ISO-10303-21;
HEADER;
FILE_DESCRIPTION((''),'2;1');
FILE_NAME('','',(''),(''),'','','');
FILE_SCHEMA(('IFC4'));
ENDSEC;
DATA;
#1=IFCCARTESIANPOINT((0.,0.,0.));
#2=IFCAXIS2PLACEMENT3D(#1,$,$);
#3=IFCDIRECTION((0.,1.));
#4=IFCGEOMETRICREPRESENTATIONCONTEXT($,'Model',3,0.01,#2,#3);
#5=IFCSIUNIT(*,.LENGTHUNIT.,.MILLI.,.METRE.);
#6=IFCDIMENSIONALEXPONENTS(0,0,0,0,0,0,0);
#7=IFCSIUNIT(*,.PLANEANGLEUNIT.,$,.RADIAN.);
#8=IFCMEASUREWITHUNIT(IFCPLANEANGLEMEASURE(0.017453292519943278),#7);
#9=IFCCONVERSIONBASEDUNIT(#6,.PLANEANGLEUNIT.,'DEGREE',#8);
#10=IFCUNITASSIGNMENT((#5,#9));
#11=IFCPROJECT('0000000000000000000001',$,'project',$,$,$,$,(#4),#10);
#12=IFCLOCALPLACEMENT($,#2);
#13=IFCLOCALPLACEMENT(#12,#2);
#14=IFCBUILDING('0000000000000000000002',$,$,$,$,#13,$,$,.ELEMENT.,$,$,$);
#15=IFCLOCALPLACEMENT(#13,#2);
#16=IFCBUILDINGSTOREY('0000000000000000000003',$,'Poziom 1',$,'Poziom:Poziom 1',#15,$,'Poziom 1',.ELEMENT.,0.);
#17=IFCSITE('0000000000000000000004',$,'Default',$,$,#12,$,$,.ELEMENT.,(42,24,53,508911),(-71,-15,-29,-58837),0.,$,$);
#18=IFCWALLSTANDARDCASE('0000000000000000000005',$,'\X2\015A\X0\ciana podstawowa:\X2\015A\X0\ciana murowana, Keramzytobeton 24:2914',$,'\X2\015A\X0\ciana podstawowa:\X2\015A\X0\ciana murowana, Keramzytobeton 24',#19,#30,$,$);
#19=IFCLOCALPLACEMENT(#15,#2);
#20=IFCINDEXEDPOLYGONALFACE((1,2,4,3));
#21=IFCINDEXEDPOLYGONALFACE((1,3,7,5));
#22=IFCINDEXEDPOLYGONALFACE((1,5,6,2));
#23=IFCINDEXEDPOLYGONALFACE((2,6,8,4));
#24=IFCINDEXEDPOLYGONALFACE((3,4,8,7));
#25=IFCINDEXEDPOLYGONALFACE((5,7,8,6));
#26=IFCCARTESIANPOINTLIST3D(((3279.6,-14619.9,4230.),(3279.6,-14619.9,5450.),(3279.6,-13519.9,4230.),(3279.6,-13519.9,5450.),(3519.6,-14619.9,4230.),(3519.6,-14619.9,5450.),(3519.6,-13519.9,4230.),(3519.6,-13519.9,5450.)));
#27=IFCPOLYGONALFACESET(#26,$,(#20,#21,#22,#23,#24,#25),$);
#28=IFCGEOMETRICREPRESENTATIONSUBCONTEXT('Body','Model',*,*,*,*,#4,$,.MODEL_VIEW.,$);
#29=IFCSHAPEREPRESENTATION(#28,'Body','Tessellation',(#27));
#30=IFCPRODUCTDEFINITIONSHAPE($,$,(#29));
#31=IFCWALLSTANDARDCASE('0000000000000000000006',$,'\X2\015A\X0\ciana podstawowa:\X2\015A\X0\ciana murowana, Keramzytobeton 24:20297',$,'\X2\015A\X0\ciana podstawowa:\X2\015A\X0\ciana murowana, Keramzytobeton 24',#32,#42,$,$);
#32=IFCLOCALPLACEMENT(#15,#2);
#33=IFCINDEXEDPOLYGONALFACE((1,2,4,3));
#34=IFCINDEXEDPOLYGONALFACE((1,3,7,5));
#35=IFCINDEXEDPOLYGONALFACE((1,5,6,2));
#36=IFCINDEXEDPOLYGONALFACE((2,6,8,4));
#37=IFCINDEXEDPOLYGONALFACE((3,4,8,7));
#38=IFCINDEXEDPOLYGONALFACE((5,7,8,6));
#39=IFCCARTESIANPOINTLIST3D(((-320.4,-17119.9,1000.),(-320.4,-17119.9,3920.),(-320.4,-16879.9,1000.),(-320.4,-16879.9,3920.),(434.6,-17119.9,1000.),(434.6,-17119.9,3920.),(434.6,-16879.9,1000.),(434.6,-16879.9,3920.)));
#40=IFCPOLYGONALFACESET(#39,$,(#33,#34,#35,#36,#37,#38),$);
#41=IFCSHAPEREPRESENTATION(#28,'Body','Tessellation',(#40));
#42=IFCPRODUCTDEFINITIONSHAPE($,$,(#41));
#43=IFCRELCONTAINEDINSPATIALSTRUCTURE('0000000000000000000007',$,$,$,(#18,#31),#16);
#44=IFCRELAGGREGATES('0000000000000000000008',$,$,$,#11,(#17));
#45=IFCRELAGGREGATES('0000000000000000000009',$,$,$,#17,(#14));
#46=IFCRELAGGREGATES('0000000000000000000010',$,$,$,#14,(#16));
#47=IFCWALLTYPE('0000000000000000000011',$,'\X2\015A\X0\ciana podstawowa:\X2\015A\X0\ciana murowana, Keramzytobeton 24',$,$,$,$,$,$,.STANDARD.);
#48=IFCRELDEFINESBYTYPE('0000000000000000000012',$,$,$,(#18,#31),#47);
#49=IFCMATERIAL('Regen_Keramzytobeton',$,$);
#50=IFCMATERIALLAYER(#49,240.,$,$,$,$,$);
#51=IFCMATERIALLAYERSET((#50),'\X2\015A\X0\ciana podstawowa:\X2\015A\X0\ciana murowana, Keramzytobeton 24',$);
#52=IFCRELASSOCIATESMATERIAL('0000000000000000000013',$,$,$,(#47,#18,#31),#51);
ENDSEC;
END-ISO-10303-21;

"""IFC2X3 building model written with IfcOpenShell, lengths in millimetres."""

from ifc_helpers import new_model, entity, si_unit, converted_unit, direction, frame, frame_2d, origin, place, context, subcontext, project, spatial, rectangle, extrude, material, layer, layer_set, layer_usage, type_object, element, save


model = new_model("IFC2X3")

# Units and contexts
model_context = context("Model", 3, precision=0.01, world=origin(), true_north=direction((0.0, 1.0)))
body_context = subcontext(model_context, "Body", "Model", "MODEL_VIEW")
ifc_project = project(units=[si_unit("LENGTHUNIT", "METRE", prefix="MILLI"), converted_unit("PLANEANGLEUNIT", "DEGREE", entity("IfcPlaneAngleMeasure", 0.017453292519943278), si_unit("PLANEANGLEUNIT", "RADIAN"), dimensions=[0, 0, 0, 0, 0, 0, 0])], contexts=[model_context])

# Site, building, storey
site_placement = place(None, origin())
site = spatial("IfcSite", under=ifc_project, at=site_placement, Name="Default", CompositionType="ELEMENT", RefLatitude=(42, 24, 53, 508911), RefLongitude=(-71, -15, -29, -58837), RefElevation=0.0)
building_placement = place(site_placement, origin())
building = spatial("IfcBuilding", under=site, at=building_placement, CompositionType="ELEMENT")
storey_placement = place(building_placement, origin())
storey = spatial("IfcBuildingStorey", under=building, at=storey_placement, Name="Poziom 1", ObjectType="Poziom:Poziom 1", LongName="Poziom 1", CompositionType="ELEMENT", Elevation=0.0)

# Shared definitions
ifc_material_1 = material(Name="Regen_Keramzytobeton")
ifc_layer_1 = layer(ifc_material_1, 240.0)
ifc_layer_set_1 = layer_set([ifc_layer_1], Name="Ściana podstawowa:Ściana murowana, Keramzytobeton 24")
wall_type = type_object("IfcWallType", Name="Ściana podstawowa:Ściana murowana, Keramzytobeton 24", PredefinedType="STANDARD", material=ifc_layer_set_1)

# Walls
ifc_layer_usage_1 = layer_usage(ifc_layer_set_1, "AXIS2", "NEGATIVE", 120.0)
wall_1_placement = place(storey_placement, frame((3399.6, -14619.9, 4230.0), z_axis=(0.0, 0.0, 1.0), x_axis=(0.0, 1.0, 0.0)))
element("IfcWallStandardCase", 1, at=wall_1_placement, inside=storey, type_object=wall_type, material=ifc_layer_usage_1, Name="Ściana podstawowa:Ściana murowana, Keramzytobeton 24:2914", ObjectType="Ściana podstawowa:Ściana murowana, Keramzytobeton 24", context=body_context, shape_type="SweptSolid", body=[
    extrude(rectangle(XDim=1100.0, YDim=240.0, at=frame_2d((550.0, 0.0), x_axis=(-1.0, 0.0))), origin(), (0.0, 0.0, 1.0), 1220.0),
])
ifc_layer_usage_2 = layer_usage(ifc_layer_set_1, "AXIS2", "NEGATIVE", 120.0)
wall_2_placement = place(storey_placement, frame((434.6, -16999.9, 1000.0), z_axis=(0.0, 0.0, 1.0), x_axis=(-1.0, 0.0, 0.0)))
element("IfcWallStandardCase", 2, at=wall_2_placement, inside=storey, type_object=wall_type, material=ifc_layer_usage_2, Name="Ściana podstawowa:Ściana murowana, Keramzytobeton 24:20297", ObjectType="Ściana podstawowa:Ściana murowana, Keramzytobeton 24", context=body_context, shape_type="SweptSolid", body=[
    extrude(rectangle(XDim=755.0, YDim=240.0, at=frame_2d((377.5, 0.0), x_axis=(-1.0, 0.0))), origin(), (0.0, 0.0, 1.0), 2920.0),
])

save(model, "model.ifc")
